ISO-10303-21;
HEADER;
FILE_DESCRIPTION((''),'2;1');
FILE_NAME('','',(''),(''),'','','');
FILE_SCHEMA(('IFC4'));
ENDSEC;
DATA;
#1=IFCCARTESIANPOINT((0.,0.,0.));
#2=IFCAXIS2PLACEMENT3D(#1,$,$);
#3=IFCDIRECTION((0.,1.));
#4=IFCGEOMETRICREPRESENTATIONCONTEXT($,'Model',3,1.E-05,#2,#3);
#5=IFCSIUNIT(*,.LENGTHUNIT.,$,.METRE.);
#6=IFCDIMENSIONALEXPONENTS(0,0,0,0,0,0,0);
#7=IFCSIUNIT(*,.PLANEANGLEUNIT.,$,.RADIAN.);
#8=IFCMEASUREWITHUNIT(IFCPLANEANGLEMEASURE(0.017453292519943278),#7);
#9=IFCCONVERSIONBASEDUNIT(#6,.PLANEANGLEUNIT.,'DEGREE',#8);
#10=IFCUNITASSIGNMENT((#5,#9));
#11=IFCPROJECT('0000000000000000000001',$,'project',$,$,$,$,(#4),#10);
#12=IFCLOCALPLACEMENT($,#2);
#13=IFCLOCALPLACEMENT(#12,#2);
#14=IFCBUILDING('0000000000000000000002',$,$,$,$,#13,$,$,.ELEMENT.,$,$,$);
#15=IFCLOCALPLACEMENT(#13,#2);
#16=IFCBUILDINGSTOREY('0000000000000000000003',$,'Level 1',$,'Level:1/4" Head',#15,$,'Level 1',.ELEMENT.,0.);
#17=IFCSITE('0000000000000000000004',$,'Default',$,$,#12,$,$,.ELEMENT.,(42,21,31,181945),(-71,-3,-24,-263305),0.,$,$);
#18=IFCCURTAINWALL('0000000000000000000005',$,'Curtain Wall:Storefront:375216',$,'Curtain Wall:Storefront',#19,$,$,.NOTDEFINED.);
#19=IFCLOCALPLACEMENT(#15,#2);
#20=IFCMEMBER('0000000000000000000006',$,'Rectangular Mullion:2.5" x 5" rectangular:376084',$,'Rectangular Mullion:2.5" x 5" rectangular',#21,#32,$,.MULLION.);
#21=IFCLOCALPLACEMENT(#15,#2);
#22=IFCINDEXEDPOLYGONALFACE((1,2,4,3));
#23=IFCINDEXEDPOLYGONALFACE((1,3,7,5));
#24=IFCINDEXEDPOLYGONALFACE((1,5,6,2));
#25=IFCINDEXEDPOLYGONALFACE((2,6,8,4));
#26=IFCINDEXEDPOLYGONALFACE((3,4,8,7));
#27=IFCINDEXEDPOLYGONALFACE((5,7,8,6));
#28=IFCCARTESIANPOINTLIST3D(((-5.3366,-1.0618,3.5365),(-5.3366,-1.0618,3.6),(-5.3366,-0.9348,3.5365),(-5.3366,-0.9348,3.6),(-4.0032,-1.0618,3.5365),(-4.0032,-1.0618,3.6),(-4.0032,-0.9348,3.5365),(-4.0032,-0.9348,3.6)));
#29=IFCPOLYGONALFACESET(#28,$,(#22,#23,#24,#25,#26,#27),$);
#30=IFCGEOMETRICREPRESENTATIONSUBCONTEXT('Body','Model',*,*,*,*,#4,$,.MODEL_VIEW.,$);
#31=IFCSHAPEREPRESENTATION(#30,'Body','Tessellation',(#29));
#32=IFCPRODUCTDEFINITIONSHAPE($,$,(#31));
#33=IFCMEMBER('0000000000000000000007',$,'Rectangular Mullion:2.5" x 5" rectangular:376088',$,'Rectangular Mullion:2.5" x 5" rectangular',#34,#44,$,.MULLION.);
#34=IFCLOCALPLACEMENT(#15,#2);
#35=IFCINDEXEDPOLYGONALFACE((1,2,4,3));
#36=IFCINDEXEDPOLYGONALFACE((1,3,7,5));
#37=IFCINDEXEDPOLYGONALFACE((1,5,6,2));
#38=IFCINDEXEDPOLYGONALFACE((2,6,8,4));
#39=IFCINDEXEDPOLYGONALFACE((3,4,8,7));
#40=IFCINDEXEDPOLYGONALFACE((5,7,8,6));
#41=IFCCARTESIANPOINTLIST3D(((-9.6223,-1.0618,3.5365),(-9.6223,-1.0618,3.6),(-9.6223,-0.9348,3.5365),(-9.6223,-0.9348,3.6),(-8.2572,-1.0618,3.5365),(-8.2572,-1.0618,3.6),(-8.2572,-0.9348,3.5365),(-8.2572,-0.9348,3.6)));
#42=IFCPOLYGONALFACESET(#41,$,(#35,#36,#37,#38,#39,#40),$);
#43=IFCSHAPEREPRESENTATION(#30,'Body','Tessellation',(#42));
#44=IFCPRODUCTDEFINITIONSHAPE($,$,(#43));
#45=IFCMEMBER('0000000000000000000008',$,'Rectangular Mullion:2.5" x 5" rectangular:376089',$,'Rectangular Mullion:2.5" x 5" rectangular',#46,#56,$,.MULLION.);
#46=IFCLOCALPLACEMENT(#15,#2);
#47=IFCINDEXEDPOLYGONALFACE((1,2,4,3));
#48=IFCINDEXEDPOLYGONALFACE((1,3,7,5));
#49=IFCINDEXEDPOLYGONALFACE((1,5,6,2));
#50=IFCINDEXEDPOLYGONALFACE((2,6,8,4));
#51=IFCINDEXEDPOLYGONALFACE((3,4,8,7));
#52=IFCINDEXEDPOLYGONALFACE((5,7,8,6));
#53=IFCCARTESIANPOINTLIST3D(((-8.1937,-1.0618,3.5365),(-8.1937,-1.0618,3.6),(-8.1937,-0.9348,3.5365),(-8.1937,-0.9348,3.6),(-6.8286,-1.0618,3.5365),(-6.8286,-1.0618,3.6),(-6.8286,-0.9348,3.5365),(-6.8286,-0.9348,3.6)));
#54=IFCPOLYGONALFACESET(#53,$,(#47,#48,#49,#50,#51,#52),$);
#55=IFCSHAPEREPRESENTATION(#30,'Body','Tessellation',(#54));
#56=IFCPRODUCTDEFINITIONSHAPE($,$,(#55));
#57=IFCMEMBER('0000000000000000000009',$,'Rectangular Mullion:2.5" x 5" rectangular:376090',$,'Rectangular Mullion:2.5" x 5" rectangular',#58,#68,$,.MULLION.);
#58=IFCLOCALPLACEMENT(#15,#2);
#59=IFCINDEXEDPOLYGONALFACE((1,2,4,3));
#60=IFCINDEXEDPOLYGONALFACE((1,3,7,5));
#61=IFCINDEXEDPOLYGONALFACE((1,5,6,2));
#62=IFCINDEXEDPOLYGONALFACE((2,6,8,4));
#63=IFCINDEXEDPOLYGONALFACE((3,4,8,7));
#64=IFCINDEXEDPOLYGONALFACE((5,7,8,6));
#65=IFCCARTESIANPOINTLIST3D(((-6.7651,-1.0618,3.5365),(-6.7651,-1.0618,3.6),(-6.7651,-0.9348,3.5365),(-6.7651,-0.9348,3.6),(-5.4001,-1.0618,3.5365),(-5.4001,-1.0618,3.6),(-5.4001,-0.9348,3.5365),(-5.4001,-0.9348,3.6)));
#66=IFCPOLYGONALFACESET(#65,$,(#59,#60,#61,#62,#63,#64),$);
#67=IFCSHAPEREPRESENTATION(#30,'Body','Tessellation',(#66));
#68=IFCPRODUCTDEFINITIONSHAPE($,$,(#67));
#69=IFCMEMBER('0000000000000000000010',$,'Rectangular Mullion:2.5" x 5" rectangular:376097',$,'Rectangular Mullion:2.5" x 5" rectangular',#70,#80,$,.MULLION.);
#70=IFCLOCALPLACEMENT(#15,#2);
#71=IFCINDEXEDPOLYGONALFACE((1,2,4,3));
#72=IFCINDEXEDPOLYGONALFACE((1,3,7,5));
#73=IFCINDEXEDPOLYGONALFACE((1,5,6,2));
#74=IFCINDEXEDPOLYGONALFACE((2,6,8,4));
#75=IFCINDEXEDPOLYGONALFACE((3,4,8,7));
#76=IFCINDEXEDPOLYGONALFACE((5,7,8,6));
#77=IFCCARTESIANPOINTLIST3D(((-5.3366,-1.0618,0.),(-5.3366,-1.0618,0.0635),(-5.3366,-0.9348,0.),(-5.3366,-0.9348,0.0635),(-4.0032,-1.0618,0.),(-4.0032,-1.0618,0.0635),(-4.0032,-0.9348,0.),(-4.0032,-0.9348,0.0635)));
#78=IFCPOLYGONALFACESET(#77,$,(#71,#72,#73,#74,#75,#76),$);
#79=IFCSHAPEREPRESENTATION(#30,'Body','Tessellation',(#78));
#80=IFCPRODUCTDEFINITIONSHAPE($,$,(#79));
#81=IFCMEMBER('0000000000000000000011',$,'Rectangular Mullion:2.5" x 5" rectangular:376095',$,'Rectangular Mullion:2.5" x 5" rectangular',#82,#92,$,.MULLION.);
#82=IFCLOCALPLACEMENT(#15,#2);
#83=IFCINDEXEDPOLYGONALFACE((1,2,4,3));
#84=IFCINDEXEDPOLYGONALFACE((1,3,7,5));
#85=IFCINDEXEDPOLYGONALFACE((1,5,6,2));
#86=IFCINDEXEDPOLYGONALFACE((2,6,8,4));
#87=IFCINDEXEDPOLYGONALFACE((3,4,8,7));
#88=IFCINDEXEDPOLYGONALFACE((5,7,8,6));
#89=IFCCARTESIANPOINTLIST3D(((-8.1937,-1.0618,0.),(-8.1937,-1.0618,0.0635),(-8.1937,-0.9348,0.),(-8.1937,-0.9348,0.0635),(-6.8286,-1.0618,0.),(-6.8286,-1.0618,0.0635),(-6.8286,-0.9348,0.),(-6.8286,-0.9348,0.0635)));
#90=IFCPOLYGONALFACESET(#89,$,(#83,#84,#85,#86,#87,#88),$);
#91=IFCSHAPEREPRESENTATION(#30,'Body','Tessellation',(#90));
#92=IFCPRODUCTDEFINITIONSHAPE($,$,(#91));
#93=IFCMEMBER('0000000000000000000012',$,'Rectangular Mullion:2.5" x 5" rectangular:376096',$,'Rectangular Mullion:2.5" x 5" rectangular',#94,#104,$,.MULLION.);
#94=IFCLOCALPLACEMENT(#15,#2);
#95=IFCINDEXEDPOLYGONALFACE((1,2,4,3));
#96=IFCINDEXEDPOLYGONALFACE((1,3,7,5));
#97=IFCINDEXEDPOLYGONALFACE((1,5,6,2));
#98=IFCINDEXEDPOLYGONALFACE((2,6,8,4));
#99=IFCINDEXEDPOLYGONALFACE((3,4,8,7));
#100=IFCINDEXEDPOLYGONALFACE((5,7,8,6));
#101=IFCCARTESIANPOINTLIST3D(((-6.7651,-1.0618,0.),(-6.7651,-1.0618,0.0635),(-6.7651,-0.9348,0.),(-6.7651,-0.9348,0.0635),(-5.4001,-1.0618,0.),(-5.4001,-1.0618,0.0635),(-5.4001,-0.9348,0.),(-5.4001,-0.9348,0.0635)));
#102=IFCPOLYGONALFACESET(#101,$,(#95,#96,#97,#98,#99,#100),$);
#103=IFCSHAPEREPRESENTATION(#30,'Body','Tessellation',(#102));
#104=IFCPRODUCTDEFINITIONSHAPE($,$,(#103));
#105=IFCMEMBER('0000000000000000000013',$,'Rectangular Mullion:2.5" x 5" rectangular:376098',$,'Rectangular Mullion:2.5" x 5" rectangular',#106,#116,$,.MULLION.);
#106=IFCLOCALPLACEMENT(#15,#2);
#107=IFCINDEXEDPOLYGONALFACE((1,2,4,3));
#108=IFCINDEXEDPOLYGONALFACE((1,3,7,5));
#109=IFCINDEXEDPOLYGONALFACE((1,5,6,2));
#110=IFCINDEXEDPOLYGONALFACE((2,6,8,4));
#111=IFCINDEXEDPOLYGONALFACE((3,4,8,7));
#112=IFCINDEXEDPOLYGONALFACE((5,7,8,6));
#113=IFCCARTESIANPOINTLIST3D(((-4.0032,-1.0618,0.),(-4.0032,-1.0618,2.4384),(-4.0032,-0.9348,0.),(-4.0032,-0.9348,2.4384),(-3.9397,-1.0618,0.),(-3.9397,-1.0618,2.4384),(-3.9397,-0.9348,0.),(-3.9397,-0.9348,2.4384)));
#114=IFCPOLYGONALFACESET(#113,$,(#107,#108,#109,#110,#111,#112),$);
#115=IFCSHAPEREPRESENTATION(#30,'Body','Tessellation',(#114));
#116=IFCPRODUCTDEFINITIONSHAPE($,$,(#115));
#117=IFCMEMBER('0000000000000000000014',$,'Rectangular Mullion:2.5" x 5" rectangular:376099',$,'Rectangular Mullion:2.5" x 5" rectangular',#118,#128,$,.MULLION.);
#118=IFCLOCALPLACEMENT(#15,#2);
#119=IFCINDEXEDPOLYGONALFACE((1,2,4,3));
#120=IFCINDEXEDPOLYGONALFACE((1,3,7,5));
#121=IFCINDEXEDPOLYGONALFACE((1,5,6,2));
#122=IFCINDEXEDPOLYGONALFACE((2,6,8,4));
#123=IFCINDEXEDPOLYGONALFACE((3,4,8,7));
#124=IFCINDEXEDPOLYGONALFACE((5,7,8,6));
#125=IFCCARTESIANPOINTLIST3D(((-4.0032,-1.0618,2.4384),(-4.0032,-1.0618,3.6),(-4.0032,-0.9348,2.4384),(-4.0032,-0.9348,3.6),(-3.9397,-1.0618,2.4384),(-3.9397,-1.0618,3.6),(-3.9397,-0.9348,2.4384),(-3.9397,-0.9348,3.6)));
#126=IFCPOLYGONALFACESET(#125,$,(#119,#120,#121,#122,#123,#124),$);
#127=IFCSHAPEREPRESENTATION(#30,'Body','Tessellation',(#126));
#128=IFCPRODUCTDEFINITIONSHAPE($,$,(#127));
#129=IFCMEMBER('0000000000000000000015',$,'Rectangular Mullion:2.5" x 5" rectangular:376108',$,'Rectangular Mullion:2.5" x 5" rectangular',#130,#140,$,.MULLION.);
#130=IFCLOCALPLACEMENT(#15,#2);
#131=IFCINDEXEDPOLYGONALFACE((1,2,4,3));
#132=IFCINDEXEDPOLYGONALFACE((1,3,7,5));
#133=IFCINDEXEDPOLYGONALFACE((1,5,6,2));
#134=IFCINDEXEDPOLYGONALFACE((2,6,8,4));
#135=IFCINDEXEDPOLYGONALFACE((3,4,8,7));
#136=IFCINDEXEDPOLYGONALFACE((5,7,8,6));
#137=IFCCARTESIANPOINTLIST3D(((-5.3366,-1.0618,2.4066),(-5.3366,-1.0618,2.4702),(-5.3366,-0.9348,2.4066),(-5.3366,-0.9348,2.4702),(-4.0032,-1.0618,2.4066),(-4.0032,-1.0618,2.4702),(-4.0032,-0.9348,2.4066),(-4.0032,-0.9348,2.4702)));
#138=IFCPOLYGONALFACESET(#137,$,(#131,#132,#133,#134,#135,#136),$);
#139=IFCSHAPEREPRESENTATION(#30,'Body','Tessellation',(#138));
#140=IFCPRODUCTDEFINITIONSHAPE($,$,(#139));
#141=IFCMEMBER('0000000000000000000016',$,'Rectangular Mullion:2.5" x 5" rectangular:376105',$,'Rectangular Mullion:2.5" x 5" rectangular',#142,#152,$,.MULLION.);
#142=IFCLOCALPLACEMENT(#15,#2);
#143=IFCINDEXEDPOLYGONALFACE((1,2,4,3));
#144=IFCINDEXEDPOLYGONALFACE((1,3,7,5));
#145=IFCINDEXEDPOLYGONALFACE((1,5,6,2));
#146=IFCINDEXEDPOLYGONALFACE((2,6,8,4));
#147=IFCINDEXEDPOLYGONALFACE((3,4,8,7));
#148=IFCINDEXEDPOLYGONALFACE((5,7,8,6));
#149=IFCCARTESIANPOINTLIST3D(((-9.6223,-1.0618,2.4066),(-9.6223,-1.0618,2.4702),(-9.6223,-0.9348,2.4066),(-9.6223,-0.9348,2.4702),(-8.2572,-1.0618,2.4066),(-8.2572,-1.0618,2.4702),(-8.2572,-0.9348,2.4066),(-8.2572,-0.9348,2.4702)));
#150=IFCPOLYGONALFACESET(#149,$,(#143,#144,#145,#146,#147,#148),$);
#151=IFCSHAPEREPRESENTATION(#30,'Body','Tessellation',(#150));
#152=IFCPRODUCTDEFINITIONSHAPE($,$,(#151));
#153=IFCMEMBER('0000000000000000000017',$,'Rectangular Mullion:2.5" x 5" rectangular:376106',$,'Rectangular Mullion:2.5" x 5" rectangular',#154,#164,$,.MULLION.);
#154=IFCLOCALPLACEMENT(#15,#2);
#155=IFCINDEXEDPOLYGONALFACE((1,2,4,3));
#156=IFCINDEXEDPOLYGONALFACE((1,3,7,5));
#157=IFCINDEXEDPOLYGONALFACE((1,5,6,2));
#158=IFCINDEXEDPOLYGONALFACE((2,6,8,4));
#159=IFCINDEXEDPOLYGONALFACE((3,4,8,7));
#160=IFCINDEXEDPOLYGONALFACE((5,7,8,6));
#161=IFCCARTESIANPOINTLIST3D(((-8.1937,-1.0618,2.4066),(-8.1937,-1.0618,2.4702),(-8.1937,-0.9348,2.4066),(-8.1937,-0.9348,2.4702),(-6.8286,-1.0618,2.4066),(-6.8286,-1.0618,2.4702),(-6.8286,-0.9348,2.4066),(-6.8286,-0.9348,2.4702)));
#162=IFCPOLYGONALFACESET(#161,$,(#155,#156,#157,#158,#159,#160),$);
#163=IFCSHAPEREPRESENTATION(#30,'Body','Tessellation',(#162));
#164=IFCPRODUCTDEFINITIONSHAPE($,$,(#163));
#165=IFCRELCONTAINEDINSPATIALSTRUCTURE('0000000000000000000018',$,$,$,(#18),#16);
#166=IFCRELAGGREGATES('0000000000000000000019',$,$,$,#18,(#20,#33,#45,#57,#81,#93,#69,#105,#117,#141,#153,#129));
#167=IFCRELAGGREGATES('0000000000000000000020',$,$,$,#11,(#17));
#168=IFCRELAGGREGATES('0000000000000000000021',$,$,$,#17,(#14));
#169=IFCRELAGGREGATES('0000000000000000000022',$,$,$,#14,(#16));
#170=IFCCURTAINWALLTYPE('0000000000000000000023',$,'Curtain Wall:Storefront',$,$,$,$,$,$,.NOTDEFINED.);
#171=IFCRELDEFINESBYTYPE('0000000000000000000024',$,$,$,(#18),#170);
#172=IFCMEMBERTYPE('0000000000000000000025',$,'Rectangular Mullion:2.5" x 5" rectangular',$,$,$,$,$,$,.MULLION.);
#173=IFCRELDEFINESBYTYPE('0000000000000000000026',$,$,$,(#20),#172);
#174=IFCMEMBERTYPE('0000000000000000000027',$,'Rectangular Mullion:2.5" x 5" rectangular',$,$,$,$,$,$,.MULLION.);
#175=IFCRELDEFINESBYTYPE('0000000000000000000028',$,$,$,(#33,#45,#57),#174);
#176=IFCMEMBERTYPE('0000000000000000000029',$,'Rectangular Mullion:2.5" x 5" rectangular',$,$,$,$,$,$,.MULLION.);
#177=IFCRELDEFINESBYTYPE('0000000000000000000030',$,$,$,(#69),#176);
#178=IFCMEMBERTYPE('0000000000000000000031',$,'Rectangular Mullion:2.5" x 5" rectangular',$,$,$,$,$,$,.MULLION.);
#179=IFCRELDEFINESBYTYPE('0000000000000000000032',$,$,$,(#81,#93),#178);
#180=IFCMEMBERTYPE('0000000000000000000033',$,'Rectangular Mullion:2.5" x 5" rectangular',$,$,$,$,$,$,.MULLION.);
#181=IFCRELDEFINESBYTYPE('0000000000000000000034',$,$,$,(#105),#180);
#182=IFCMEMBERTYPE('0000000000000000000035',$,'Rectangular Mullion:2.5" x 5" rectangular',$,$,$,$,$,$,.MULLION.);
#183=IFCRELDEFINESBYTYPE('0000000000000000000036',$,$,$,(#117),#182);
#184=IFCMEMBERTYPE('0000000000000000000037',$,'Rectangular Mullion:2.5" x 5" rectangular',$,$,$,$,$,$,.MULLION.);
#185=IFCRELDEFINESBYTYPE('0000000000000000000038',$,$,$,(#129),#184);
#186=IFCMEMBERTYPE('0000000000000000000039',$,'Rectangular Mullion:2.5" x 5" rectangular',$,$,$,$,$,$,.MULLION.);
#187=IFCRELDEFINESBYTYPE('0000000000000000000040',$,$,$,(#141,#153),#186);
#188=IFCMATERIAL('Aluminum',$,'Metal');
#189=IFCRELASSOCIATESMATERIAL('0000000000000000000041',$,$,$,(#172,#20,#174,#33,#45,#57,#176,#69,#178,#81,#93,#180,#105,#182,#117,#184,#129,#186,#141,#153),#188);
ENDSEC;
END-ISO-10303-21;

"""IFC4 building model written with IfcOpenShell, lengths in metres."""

from ifc_helpers import new_model, entity, si_unit, converted_unit, direction, frame, origin, place, context, subcontext, project, spatial, indexed_curve, outline, extrude, source, transform, mapped, material, type_object, type_shapes, element, aggregate, save


model = new_model("IFC4")

# Units and contexts
model_context = context("Model", 3, precision=1e-05, world=origin(), true_north=direction((0.0, 1.0)))
body_context = subcontext(model_context, "Body", "Model", "MODEL_VIEW")
ifc_project = project(units=[si_unit("LENGTHUNIT", "METRE"), converted_unit("PLANEANGLEUNIT", "DEGREE", entity("IfcPlaneAngleMeasure", 0.017453292519943278), si_unit("PLANEANGLEUNIT", "RADIAN"), dimensions=[0, 0, 0, 0, 0, 0, 0])], contexts=[model_context])

# Site, building, storey
site_placement = place(None, origin())
site = spatial("IfcSite", under=ifc_project, at=site_placement, Name="Default", CompositionType="ELEMENT", RefLatitude=(42, 21, 31, 181945), RefLongitude=(-71, -3, -24, -263305), RefElevation=0.0)
building_placement = place(site_placement, origin())
building = spatial("IfcBuilding", under=site, at=building_placement, CompositionType="ELEMENT")
storey_placement = place(building_placement, origin())
storey = spatial("IfcBuildingStorey", under=building, at=storey_placement, Name="Level 1", ObjectType="Level:1/4\" Head", LongName="Level 1", CompositionType="ELEMENT", Elevation=0.0)

# Curtain wall, members
curtain_wall_type = type_object("IfcCurtainWallType", Name="Curtain Wall:Storefront", PredefinedType="NOTDEFINED")
curtain_wall_placement = place(storey_placement, origin())
curtain_wall = element("IfcCurtainWall", 1, at=curtain_wall_placement, inside=storey, type_object=curtain_wall_type, Name="Curtain Wall:Storefront:375216", ObjectType="Curtain Wall:Storefront", PredefinedType="NOTDEFINED")
ifc_material_1 = material(Name="Aluminum", Category="Metal")
member_type_1 = type_object("IfcMemberType", Name="Rectangular Mullion:2.5\" x 5\" rectangular", PredefinedType="MULLION", material=ifc_material_1)
shared_shape_1 = source(origin(), body_context, "Body", "SweptSolid", [
    extrude(outline(indexed_curve([(-0.0318, -0.0635), (0.0318, -0.0635), (0.0318, 0.0635), (-0.0318, 0.0635), (-0.0318, -0.0635)], self_intersect=False)), frame((-0.0318, 0.0, -1.3333), z_axis=(0.0, 0.0, 1.0), x_axis=(-1.0, 0.0, 0.0)), (0.0, 0.0, 1.0), 1.3333),
])
type_shapes(member_type_1, [shared_shape_1])
member_1_placement = place(curtain_wall_placement, frame((-4.0032, -0.9983, 3.6), z_axis=(1.0, 0.0, 0.0), x_axis=(0.0, 0.0, 1.0)))
member_1 = element("IfcMember", 2, at=member_1_placement, type_object=member_type_1, material=ifc_material_1, Name="Rectangular Mullion:2.5\" x 5\" rectangular:376084", ObjectType="Rectangular Mullion:2.5\" x 5\" rectangular", PredefinedType="MULLION", context=body_context, shape_type="MappedRepresentation", body=[
    mapped(shared_shape_1, transform((0.0, 0.0, 0.0), scale=1.0)),
])
member_type_2 = type_object("IfcMemberType", Name="Rectangular Mullion:2.5\" x 5\" rectangular", PredefinedType="MULLION", material=ifc_material_1)
shared_shape_2 = source(origin(), body_context, "Body", "SweptSolid", [
    extrude(outline(indexed_curve([(-0.0318, -0.0635), (0.0318, -0.0635), (0.0318, 0.0635), (-0.0318, 0.0635), (-0.0318, -0.0635)], self_intersect=False)), frame((-0.0318, 0.0, -1.3651), z_axis=(0.0, 0.0, 1.0), x_axis=(-1.0, 0.0, 0.0)), (0.0, 0.0, 1.0), 1.3651),
])
type_shapes(member_type_2, [shared_shape_2])
member_2_placement = place(curtain_wall_placement, frame((-8.2572, -0.9983, 3.6), z_axis=(1.0, 0.0, 0.0), x_axis=(0.0, 0.0, 1.0)))
member_2 = element("IfcMember", 3, at=member_2_placement, type_object=member_type_2, material=ifc_material_1, Name="Rectangular Mullion:2.5\" x 5\" rectangular:376088", ObjectType="Rectangular Mullion:2.5\" x 5\" rectangular", PredefinedType="MULLION", context=body_context, shape_type="MappedRepresentation", body=[
    mapped(shared_shape_2, transform((0.0, 0.0, 0.0), scale=1.0)),
])
member_3_placement = place(curtain_wall_placement, frame((-6.8286, -0.9983, 3.6), z_axis=(1.0, 0.0, 0.0), x_axis=(0.0, 0.0, 1.0)))
member_3 = element("IfcMember", 4, at=member_3_placement, type_object=member_type_2, material=ifc_material_1, Name="Rectangular Mullion:2.5\" x 5\" rectangular:376089", ObjectType="Rectangular Mullion:2.5\" x 5\" rectangular", PredefinedType="MULLION", context=body_context, shape_type="MappedRepresentation", body=[
    mapped(shared_shape_2, transform((0.0, 0.0, 0.0), scale=1.0)),
])
member_4_placement = place(curtain_wall_placement, frame((-5.4001, -0.9983, 3.6), z_axis=(1.0, 0.0, 0.0), x_axis=(0.0, 0.0, 1.0)))
member_4 = element("IfcMember", 5, at=member_4_placement, type_object=member_type_2, material=ifc_material_1, Name="Rectangular Mullion:2.5\" x 5\" rectangular:376090", ObjectType="Rectangular Mullion:2.5\" x 5\" rectangular", PredefinedType="MULLION", context=body_context, shape_type="MappedRepresentation", body=[
    mapped(shared_shape_2, transform((0.0, 0.0, 0.0), scale=1.0)),
])
member_type_3 = type_object("IfcMemberType", Name="Rectangular Mullion:2.5\" x 5\" rectangular", PredefinedType="MULLION", material=ifc_material_1)
shared_shape_3 = source(origin(), body_context, "Body", "SweptSolid", [
    extrude(outline(indexed_curve([(-0.0318, -0.0635), (0.0318, -0.0635), (0.0318, 0.0635), (-0.0318, 0.0635), (-0.0318, -0.0635)], self_intersect=False)), frame((-0.0318, 0.0, -1.3333), z_axis=(0.0, 0.0, 1.0), x_axis=(-1.0, 0.0, 0.0)), (0.0, 0.0, 1.0), 1.3333),
])
type_shapes(member_type_3, [shared_shape_3])
member_5_placement = place(curtain_wall_placement, frame((-5.3366, -0.9983, 0.0), z_axis=(-1.0, 0.0, 0.0), x_axis=(0.0, 0.0, -1.0)))
member_5 = element("IfcMember", 6, at=member_5_placement, type_object=member_type_3, material=ifc_material_1, Name="Rectangular Mullion:2.5\" x 5\" rectangular:376097", ObjectType="Rectangular Mullion:2.5\" x 5\" rectangular", PredefinedType="MULLION", context=body_context, shape_type="MappedRepresentation", body=[
    mapped(shared_shape_3, transform((0.0, 0.0, 0.0), scale=1.0)),
])
member_type_4 = type_object("IfcMemberType", Name="Rectangular Mullion:2.5\" x 5\" rectangular", PredefinedType="MULLION", material=ifc_material_1)
shared_shape_4 = source(origin(), body_context, "Body", "SweptSolid", [
    extrude(outline(indexed_curve([(-0.0318, -0.0635), (0.0318, -0.0635), (0.0318, 0.0635), (-0.0318, 0.0635), (-0.0318, -0.0635)], self_intersect=False)), frame((-0.0318, 0.0, -1.3651), z_axis=(0.0, 0.0, 1.0), x_axis=(-1.0, 0.0, 0.0)), (0.0, 0.0, 1.0), 1.3651),
])
type_shapes(member_type_4, [shared_shape_4])
member_6_placement = place(curtain_wall_placement, frame((-8.1937, -0.9983, 0.0), z_axis=(-1.0, 0.0, 0.0), x_axis=(0.0, 0.0, -1.0)))
member_6 = element("IfcMember", 7, at=member_6_placement, type_object=member_type_4, material=ifc_material_1, Name="Rectangular Mullion:2.5\" x 5\" rectangular:376095", ObjectType="Rectangular Mullion:2.5\" x 5\" rectangular", PredefinedType="MULLION", context=body_context, shape_type="MappedRepresentation", body=[
    mapped(shared_shape_4, transform((0.0, 0.0, 0.0), scale=1.0)),
])
member_7_placement = place(curtain_wall_placement, frame((-6.7651, -0.9983, 0.0), z_axis=(-1.0, 0.0, 0.0), x_axis=(0.0, 0.0, -1.0)))
member_7 = element("IfcMember", 8, at=member_7_placement, type_object=member_type_4, material=ifc_material_1, Name="Rectangular Mullion:2.5\" x 5\" rectangular:376096", ObjectType="Rectangular Mullion:2.5\" x 5\" rectangular", PredefinedType="MULLION", context=body_context, shape_type="MappedRepresentation", body=[
    mapped(shared_shape_4, transform((0.0, 0.0, 0.0), scale=1.0)),
])
member_type_5 = type_object("IfcMemberType", Name="Rectangular Mullion:2.5\" x 5\" rectangular", PredefinedType="MULLION", material=ifc_material_1)
shared_shape_5 = source(origin(), body_context, "Body", "SweptSolid", [
    extrude(outline(indexed_curve([(-0.0318, -0.0635), (0.0318, -0.0635), (0.0318, 0.0635), (-0.0318, 0.0635), (-0.0318, -0.0635)], self_intersect=False)), frame((-0.0318, 0.0, -2.4384), z_axis=(0.0, 0.0, 1.0), x_axis=(-1.0, 0.0, 0.0)), (0.0, 0.0, 1.0), 2.4384),
])
type_shapes(member_type_5, [shared_shape_5])
member_8_placement = place(curtain_wall_placement, frame((-3.9397, -0.9983, 0.0), z_axis=(0.0, 0.0, -1.0), x_axis=(1.0, 0.0, 0.0)))
member_8 = element("IfcMember", 9, at=member_8_placement, type_object=member_type_5, material=ifc_material_1, Name="Rectangular Mullion:2.5\" x 5\" rectangular:376098", ObjectType="Rectangular Mullion:2.5\" x 5\" rectangular", PredefinedType="MULLION", context=body_context, shape_type="MappedRepresentation", body=[
    mapped(shared_shape_5, transform((0.0, 0.0, 0.0), scale=1.0)),
])
member_type_6 = type_object("IfcMemberType", Name="Rectangular Mullion:2.5\" x 5\" rectangular", PredefinedType="MULLION", material=ifc_material_1)
shared_shape_6 = source(origin(), body_context, "Body", "SweptSolid", [
    extrude(outline(indexed_curve([(-0.0318, -0.0635), (0.0318, -0.0635), (0.0318, 0.0635), (-0.0318, 0.0635), (-0.0318, -0.0635)], self_intersect=False)), frame((-0.0318, 0.0, -1.1616), z_axis=(0.0, 0.0, 1.0), x_axis=(-1.0, 0.0, 0.0)), (0.0, 0.0, 1.0), 1.1616),
])
type_shapes(member_type_6, [shared_shape_6])
member_9_placement = place(curtain_wall_placement, frame((-3.9397, -0.9983, 2.4384), z_axis=(0.0, 0.0, -1.0), x_axis=(1.0, 0.0, 0.0)))
member_9 = element("IfcMember", 10, at=member_9_placement, type_object=member_type_6, material=ifc_material_1, Name="Rectangular Mullion:2.5\" x 5\" rectangular:376099", ObjectType="Rectangular Mullion:2.5\" x 5\" rectangular", PredefinedType="MULLION", context=body_context, shape_type="MappedRepresentation", body=[
    mapped(shared_shape_6, transform((0.0, 0.0, 0.0), scale=1.0)),
])
member_type_7 = type_object("IfcMemberType", Name="Rectangular Mullion:2.5\" x 5\" rectangular", PredefinedType="MULLION", material=ifc_material_1)
shared_shape_7 = source(origin(), body_context, "Body", "SweptSolid", [
    extrude(outline(indexed_curve([(-0.0318, -0.0635), (0.0318, -0.0635), (0.0318, 0.0635), (-0.0318, 0.0635), (-0.0318, -0.0635)], self_intersect=False)), frame((0.0, 0.0, -1.3333), z_axis=(0.0, 0.0, 1.0), x_axis=(-1.0, 0.0, 0.0)), (0.0, 0.0, 1.0), 1.3333),
])
type_shapes(member_type_7, [shared_shape_7])
member_10_placement = place(curtain_wall_placement, frame((-4.0032, -0.9983, 2.4384), z_axis=(1.0, 0.0, 0.0), x_axis=(0.0, 0.0, 1.0)))
member_10 = element("IfcMember", 11, at=member_10_placement, type_object=member_type_7, material=ifc_material_1, Name="Rectangular Mullion:2.5\" x 5\" rectangular:376108", ObjectType="Rectangular Mullion:2.5\" x 5\" rectangular", PredefinedType="MULLION", context=body_context, shape_type="MappedRepresentation", body=[
    mapped(shared_shape_7, transform((0.0, 0.0, 0.0), scale=1.0)),
])
member_type_8 = type_object("IfcMemberType", Name="Rectangular Mullion:2.5\" x 5\" rectangular", PredefinedType="MULLION", material=ifc_material_1)
shared_shape_8 = source(origin(), body_context, "Body", "SweptSolid", [
    extrude(outline(indexed_curve([(-0.0318, -0.0635), (0.0318, -0.0635), (0.0318, 0.0635), (-0.0318, 0.0635), (-0.0318, -0.0635)], self_intersect=False)), frame((0.0, 0.0, -1.3651), z_axis=(0.0, 0.0, 1.0), x_axis=(-1.0, 0.0, 0.0)), (0.0, 0.0, 1.0), 1.3651),
])
type_shapes(member_type_8, [shared_shape_8])
member_11_placement = place(curtain_wall_placement, frame((-8.2572, -0.9983, 2.4384), z_axis=(1.0, 0.0, 0.0), x_axis=(0.0, 0.0, 1.0)))
member_11 = element("IfcMember", 12, at=member_11_placement, type_object=member_type_8, material=ifc_material_1, Name="Rectangular Mullion:2.5\" x 5\" rectangular:376105", ObjectType="Rectangular Mullion:2.5\" x 5\" rectangular", PredefinedType="MULLION", context=body_context, shape_type="MappedRepresentation", body=[
    mapped(shared_shape_8, transform((0.0, 0.0, 0.0), scale=1.0)),
])
member_12_placement = place(curtain_wall_placement, frame((-6.8286, -0.9983, 2.4384), z_axis=(1.0, 0.0, 0.0), x_axis=(0.0, 0.0, 1.0)))
member_12 = element("IfcMember", 13, at=member_12_placement, type_object=member_type_8, material=ifc_material_1, Name="Rectangular Mullion:2.5\" x 5\" rectangular:376106", ObjectType="Rectangular Mullion:2.5\" x 5\" rectangular", PredefinedType="MULLION", context=body_context, shape_type="MappedRepresentation", body=[
    mapped(shared_shape_8, transform((0.0, 0.0, 0.0), scale=1.0)),
])
aggregate(curtain_wall, [member_1, member_2, member_3, member_4, member_6, member_7, member_5, member_8, member_9, member_11, member_12, member_10])

save(model, "model.ifc")
